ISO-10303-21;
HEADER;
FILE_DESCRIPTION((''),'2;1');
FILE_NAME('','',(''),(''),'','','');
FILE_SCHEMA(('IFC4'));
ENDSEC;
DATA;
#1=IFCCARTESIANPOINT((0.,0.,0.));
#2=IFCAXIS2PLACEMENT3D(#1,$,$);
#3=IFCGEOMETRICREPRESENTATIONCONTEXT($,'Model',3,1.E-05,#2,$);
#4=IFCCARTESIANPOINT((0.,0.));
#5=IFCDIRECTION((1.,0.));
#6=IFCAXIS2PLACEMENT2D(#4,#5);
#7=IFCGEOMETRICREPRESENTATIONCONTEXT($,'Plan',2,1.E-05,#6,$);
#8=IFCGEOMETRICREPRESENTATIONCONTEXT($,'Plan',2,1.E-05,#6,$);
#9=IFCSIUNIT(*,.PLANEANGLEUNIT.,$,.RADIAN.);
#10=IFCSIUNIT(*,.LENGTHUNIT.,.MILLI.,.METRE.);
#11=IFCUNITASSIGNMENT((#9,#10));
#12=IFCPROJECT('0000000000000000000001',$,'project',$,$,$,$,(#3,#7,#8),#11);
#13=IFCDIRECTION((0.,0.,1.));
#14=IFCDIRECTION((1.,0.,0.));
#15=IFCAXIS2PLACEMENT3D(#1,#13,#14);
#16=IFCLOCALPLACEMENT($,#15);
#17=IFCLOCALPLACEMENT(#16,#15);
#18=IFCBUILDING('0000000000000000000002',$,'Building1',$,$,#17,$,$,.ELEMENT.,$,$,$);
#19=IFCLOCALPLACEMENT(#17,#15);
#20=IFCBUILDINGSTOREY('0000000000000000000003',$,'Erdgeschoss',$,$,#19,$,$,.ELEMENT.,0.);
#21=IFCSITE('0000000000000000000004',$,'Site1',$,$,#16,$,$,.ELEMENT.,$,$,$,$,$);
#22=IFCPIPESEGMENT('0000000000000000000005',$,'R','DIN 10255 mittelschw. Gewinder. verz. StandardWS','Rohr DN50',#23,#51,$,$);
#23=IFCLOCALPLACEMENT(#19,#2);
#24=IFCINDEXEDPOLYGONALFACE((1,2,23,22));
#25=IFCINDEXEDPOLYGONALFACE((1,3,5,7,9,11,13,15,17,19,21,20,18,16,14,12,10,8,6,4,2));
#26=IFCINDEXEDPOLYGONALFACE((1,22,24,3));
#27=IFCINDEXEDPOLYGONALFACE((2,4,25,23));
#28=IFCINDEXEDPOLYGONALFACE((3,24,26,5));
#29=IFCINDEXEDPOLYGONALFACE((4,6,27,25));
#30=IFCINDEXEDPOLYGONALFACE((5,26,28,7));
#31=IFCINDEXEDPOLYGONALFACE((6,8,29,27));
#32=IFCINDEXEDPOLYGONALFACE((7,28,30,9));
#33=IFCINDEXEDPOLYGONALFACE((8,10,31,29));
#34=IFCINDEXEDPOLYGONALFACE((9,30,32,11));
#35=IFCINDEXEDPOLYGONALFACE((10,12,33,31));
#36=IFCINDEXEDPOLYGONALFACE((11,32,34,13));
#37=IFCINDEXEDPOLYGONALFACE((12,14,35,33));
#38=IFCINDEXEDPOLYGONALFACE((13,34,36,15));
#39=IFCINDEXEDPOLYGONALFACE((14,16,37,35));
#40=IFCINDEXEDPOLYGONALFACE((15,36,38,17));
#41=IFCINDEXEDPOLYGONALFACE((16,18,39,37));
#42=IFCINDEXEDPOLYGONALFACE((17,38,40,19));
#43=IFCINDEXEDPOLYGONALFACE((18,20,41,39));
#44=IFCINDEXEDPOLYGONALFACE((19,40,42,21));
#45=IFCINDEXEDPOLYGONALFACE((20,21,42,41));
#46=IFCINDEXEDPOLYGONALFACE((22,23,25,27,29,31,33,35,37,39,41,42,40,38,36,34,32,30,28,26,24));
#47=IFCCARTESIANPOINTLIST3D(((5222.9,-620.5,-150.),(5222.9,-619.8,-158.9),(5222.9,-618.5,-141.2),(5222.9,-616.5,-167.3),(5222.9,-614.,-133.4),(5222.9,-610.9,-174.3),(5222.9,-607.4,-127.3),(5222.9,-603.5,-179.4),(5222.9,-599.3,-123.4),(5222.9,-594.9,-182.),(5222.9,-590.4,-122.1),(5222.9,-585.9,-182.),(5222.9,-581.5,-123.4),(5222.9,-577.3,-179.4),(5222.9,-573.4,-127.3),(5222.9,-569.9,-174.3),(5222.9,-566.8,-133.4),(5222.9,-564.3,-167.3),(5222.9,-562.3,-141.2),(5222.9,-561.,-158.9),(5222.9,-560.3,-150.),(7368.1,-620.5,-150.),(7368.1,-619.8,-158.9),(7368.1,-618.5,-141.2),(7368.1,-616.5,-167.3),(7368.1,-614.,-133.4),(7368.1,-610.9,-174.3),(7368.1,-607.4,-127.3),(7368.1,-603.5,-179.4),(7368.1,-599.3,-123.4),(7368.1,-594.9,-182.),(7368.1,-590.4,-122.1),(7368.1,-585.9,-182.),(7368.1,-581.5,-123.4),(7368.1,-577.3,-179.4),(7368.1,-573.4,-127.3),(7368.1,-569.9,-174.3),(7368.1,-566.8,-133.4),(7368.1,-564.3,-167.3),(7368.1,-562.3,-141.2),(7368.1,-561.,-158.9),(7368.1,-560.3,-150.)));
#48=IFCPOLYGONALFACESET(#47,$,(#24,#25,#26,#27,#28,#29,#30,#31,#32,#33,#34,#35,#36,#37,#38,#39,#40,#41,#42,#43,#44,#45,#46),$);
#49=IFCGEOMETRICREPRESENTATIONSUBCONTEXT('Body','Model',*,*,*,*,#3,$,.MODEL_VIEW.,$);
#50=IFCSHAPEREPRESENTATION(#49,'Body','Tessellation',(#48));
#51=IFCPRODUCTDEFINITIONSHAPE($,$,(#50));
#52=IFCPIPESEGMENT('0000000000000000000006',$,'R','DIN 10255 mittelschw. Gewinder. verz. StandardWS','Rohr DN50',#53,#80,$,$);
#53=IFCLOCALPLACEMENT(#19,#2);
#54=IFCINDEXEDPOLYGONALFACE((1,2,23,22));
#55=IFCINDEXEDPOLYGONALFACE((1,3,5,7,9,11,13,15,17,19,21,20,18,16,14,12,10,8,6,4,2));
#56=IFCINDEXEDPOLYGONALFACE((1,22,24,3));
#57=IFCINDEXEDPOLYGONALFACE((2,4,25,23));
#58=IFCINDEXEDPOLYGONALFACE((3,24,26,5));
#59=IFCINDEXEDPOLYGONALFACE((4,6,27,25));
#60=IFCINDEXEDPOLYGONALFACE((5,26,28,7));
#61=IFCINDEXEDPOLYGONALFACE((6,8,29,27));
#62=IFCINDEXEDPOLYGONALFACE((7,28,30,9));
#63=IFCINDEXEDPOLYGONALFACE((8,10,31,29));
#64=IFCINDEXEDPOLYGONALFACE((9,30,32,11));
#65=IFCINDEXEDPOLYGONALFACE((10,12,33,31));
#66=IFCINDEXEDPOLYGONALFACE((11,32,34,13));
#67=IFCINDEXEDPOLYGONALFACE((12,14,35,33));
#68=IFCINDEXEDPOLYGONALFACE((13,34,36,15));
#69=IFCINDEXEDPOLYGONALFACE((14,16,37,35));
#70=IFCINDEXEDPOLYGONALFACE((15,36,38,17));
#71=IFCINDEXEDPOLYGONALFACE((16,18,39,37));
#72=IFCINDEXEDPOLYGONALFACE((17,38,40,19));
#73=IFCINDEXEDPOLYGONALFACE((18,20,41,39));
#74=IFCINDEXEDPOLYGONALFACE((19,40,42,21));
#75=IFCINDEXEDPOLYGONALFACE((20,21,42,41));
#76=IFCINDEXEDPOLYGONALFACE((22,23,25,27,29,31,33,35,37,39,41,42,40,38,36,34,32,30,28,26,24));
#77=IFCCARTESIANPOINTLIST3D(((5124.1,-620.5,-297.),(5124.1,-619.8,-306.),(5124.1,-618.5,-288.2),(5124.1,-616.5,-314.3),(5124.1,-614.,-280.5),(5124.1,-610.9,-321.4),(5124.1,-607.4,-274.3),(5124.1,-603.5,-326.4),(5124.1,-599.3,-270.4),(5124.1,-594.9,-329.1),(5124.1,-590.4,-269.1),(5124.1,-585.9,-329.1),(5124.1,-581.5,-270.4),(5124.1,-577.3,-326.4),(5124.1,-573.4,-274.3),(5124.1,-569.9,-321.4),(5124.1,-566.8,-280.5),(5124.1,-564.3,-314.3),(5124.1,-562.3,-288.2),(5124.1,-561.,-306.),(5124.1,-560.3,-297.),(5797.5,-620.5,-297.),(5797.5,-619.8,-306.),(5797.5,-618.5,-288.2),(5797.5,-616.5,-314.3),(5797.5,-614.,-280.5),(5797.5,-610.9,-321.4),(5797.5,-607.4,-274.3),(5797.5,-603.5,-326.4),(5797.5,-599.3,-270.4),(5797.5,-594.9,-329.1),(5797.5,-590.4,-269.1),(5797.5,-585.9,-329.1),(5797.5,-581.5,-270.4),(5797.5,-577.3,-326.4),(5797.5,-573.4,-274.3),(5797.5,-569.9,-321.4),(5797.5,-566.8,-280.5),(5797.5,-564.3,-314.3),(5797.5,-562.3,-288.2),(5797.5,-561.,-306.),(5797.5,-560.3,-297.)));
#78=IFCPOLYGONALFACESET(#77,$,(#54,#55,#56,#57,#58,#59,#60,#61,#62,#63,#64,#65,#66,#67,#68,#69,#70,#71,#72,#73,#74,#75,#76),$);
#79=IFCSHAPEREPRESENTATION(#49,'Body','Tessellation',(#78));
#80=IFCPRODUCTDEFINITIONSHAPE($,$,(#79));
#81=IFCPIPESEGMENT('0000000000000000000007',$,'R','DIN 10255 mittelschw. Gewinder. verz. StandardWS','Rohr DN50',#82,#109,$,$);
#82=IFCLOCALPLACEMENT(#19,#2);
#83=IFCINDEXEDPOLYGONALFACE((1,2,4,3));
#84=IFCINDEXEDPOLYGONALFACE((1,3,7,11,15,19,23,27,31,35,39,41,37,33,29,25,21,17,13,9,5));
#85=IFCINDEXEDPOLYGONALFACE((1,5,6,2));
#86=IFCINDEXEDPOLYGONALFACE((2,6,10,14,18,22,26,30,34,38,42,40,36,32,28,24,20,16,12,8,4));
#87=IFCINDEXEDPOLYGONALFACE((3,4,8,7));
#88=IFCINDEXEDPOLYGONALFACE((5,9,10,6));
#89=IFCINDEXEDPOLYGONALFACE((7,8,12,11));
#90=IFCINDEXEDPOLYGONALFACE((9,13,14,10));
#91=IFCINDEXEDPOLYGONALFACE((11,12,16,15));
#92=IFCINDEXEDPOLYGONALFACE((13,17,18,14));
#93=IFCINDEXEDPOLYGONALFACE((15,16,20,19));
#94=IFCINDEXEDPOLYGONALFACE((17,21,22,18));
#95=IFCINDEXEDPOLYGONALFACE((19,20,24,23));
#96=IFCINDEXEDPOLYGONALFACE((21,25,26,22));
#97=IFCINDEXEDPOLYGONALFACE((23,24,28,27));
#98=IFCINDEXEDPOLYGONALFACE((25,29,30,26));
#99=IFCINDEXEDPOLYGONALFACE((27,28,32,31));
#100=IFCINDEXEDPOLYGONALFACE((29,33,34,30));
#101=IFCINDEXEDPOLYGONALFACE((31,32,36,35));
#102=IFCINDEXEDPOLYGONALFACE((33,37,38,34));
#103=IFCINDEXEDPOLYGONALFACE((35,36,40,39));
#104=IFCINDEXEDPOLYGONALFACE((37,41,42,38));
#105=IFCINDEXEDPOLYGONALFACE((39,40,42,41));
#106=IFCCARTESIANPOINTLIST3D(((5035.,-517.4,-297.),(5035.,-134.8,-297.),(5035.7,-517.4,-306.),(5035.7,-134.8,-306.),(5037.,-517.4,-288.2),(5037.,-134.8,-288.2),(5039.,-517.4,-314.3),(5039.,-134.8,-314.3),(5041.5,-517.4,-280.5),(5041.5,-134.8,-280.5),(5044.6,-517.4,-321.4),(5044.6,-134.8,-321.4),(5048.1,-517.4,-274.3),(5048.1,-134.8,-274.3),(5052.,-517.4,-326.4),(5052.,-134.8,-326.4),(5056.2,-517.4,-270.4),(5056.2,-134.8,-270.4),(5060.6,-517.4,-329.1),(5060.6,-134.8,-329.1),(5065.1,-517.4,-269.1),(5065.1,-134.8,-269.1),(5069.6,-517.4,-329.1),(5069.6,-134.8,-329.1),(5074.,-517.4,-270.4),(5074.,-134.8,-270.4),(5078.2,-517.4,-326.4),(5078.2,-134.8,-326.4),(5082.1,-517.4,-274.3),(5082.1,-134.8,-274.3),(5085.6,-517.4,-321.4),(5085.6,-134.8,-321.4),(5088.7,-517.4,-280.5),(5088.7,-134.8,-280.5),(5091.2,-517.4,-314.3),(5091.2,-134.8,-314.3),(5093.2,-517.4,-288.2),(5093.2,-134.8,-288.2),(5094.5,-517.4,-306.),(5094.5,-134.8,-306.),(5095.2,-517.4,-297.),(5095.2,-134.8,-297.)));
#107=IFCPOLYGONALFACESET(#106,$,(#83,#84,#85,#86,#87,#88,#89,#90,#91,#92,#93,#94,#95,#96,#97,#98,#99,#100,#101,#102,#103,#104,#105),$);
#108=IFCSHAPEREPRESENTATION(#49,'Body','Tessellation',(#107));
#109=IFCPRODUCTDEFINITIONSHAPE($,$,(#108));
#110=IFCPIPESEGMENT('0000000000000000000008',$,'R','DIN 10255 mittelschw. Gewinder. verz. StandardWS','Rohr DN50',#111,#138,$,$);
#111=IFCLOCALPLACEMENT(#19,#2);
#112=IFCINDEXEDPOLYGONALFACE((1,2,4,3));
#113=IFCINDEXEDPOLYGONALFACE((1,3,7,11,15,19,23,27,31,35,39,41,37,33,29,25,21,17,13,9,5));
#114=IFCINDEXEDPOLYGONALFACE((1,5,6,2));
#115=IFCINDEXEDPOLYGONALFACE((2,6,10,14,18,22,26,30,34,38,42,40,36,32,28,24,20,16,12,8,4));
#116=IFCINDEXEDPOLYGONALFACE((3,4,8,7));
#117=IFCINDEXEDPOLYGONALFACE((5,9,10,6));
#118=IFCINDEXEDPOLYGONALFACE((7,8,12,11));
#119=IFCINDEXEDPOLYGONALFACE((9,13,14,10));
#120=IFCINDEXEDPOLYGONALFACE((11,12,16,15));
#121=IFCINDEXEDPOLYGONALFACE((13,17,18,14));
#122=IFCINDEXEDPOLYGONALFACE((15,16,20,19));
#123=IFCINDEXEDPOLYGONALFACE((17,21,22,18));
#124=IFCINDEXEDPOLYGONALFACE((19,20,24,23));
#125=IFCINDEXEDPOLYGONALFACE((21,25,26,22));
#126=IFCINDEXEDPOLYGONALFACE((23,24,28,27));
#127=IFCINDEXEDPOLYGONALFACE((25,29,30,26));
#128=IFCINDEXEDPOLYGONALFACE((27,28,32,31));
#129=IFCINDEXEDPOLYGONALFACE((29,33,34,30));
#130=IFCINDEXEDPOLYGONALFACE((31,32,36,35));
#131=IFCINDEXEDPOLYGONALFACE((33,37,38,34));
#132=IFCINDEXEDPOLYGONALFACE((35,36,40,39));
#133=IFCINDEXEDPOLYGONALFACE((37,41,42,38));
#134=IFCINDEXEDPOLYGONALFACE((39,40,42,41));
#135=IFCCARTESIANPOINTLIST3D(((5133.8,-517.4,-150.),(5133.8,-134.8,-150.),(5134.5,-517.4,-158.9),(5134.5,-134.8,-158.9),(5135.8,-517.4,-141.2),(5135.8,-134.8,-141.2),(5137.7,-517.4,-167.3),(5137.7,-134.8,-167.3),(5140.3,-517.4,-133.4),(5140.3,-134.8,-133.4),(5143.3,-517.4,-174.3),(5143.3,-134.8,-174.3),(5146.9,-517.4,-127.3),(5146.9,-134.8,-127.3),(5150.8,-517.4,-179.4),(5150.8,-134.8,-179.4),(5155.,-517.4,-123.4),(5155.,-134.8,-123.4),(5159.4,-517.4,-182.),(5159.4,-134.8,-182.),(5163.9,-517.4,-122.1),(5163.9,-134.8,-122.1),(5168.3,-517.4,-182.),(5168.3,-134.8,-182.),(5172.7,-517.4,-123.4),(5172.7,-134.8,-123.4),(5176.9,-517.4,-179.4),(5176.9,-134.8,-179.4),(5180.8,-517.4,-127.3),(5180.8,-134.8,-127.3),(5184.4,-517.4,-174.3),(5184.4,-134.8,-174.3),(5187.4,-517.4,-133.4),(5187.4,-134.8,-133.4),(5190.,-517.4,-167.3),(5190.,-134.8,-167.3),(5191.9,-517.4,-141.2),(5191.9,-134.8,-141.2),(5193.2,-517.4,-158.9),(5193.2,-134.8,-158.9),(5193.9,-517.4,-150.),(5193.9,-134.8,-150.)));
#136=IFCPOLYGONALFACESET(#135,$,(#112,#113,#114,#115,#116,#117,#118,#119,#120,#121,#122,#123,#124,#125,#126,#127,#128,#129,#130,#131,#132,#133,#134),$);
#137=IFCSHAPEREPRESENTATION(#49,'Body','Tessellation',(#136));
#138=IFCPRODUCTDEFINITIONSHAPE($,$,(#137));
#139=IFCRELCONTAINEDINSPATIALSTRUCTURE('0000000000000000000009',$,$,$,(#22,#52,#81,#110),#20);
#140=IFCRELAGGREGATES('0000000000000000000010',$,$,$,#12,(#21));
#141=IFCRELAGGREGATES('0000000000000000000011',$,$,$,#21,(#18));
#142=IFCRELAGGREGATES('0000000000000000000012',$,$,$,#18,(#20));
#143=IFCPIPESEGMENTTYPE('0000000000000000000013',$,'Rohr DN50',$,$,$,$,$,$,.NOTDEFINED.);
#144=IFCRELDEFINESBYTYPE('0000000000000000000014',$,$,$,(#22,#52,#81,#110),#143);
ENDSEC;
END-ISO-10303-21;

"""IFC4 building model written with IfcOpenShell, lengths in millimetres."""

from ifc_helpers import new_model, si_unit, frame, origin, origin_with_axes, origin_2d_with_axis, place, context, subcontext, project, spatial, circle, extrude, type_object, element, save


model = new_model("IFC4")

# Units and contexts
model_context = context("Model", 3, precision=1e-05, world=origin())
plan_context_1 = context("Plan", 2, precision=1e-05, world=origin_2d_with_axis())
plan_context_2 = context("Plan", 2, precision=1e-05, world=origin_2d_with_axis())
body_context = subcontext(model_context, "Body", "Model", "MODEL_VIEW")
ifc_project = project(units=[si_unit("PLANEANGLEUNIT", "RADIAN"), si_unit("LENGTHUNIT", "METRE", prefix="MILLI")], contexts=[model_context, plan_context_1, plan_context_2])

# Site, building, storey
site_placement = place(None, origin_with_axes())
site = spatial("IfcSite", under=ifc_project, at=site_placement, Name="Site1", CompositionType="ELEMENT")
building_placement = place(site_placement, origin_with_axes())
building = spatial("IfcBuilding", under=site, at=building_placement, Name="Building1", CompositionType="ELEMENT")
storey_placement = place(building_placement, origin_with_axes())
storey = spatial("IfcBuildingStorey", under=building, at=storey_placement, Name="Erdgeschoss", CompositionType="ELEMENT", Elevation=0.0)

# Pipe segments
pipe_segment_type_1 = type_object("IfcPipeSegmentType", Name="Rohr DN50", PredefinedType="NOTDEFINED")
pipe_segment_1_placement = place(storey_placement, frame((6295.5, -590.3, -152.2), z_axis=(0.0, 0.0, 1.0), x_axis=(1.0, 0.0, 0.0)))
element("IfcPipeSegment", 1, at=pipe_segment_1_placement, inside=storey, type_object=pipe_segment_type_1, Name="R", Description="DIN 10255 mittelschw. Gewinder. verz. StandardWS", ObjectType="Rohr DN50", context=body_context, shape_type="SolidModel", body=[
    extrude(circle(Radius=30.1, at=origin_2d_with_axis()), frame((-1072.6, -0.2, 0.0), z_axis=(1.0, 0.0, 0.0), x_axis=(0.0, 0.0, 1.0)), (0.0, 0.0, 1.0), 2145.3),
])
pipe_segment_2_placement = place(storey_placement, frame((5460.8, -590.3, -299.2), z_axis=(0.0, 0.0, 1.0), x_axis=(1.0, 0.0, 0.0)))
element("IfcPipeSegment", 2, at=pipe_segment_2_placement, inside=storey, type_object=pipe_segment_type_1, Name="R", Description="DIN 10255 mittelschw. Gewinder. verz. StandardWS", ObjectType="Rohr DN50", context=body_context, shape_type="SolidModel", body=[
    extrude(circle(Radius=30.1, at=origin_2d_with_axis()), frame((-336.7, -0.2, 0.0), z_axis=(1.0, 0.0, 0.0), x_axis=(0.0, 0.0, 1.0)), (0.0, 0.0, 1.0), 673.4),
])
pipe_segment_3_placement = place(storey_placement, frame((5065.0, -326.1, -299.2), z_axis=(0.0, 0.0, 1.0), x_axis=(1.0, 0.0, 0.0)))
element("IfcPipeSegment", 3, at=pipe_segment_3_placement, inside=storey, type_object=pipe_segment_type_1, Name="R", Description="DIN 10255 mittelschw. Gewinder. verz. StandardWS", ObjectType="Rohr DN50", context=body_context, shape_type="SolidModel", body=[
    extrude(circle(Radius=30.1, at=origin_2d_with_axis()), frame((0.1, -191.3, 0.0), z_axis=(0.0, 1.0, 0.0), x_axis=(0.0, 0.0, 1.0)), (0.0, 0.0, 1.0), 382.6),
])
pipe_segment_4_placement = place(storey_placement, frame((5163.7, -326.1, -152.2), z_axis=(0.0, 0.0, 1.0), x_axis=(1.0, 0.0, 0.0)))
element("IfcPipeSegment", 4, at=pipe_segment_4_placement, inside=storey, type_object=pipe_segment_type_1, Name="R", Description="DIN 10255 mittelschw. Gewinder. verz. StandardWS", ObjectType="Rohr DN50", context=body_context, shape_type="SolidModel", body=[
    extrude(circle(Radius=30.1, at=origin_2d_with_axis()), frame((0.1, -191.3, 0.0), z_axis=(0.0, 1.0, 0.0), x_axis=(0.0, 0.0, 1.0)), (0.0, 0.0, 1.0), 382.6),
])

save(model, "model.ifc")
